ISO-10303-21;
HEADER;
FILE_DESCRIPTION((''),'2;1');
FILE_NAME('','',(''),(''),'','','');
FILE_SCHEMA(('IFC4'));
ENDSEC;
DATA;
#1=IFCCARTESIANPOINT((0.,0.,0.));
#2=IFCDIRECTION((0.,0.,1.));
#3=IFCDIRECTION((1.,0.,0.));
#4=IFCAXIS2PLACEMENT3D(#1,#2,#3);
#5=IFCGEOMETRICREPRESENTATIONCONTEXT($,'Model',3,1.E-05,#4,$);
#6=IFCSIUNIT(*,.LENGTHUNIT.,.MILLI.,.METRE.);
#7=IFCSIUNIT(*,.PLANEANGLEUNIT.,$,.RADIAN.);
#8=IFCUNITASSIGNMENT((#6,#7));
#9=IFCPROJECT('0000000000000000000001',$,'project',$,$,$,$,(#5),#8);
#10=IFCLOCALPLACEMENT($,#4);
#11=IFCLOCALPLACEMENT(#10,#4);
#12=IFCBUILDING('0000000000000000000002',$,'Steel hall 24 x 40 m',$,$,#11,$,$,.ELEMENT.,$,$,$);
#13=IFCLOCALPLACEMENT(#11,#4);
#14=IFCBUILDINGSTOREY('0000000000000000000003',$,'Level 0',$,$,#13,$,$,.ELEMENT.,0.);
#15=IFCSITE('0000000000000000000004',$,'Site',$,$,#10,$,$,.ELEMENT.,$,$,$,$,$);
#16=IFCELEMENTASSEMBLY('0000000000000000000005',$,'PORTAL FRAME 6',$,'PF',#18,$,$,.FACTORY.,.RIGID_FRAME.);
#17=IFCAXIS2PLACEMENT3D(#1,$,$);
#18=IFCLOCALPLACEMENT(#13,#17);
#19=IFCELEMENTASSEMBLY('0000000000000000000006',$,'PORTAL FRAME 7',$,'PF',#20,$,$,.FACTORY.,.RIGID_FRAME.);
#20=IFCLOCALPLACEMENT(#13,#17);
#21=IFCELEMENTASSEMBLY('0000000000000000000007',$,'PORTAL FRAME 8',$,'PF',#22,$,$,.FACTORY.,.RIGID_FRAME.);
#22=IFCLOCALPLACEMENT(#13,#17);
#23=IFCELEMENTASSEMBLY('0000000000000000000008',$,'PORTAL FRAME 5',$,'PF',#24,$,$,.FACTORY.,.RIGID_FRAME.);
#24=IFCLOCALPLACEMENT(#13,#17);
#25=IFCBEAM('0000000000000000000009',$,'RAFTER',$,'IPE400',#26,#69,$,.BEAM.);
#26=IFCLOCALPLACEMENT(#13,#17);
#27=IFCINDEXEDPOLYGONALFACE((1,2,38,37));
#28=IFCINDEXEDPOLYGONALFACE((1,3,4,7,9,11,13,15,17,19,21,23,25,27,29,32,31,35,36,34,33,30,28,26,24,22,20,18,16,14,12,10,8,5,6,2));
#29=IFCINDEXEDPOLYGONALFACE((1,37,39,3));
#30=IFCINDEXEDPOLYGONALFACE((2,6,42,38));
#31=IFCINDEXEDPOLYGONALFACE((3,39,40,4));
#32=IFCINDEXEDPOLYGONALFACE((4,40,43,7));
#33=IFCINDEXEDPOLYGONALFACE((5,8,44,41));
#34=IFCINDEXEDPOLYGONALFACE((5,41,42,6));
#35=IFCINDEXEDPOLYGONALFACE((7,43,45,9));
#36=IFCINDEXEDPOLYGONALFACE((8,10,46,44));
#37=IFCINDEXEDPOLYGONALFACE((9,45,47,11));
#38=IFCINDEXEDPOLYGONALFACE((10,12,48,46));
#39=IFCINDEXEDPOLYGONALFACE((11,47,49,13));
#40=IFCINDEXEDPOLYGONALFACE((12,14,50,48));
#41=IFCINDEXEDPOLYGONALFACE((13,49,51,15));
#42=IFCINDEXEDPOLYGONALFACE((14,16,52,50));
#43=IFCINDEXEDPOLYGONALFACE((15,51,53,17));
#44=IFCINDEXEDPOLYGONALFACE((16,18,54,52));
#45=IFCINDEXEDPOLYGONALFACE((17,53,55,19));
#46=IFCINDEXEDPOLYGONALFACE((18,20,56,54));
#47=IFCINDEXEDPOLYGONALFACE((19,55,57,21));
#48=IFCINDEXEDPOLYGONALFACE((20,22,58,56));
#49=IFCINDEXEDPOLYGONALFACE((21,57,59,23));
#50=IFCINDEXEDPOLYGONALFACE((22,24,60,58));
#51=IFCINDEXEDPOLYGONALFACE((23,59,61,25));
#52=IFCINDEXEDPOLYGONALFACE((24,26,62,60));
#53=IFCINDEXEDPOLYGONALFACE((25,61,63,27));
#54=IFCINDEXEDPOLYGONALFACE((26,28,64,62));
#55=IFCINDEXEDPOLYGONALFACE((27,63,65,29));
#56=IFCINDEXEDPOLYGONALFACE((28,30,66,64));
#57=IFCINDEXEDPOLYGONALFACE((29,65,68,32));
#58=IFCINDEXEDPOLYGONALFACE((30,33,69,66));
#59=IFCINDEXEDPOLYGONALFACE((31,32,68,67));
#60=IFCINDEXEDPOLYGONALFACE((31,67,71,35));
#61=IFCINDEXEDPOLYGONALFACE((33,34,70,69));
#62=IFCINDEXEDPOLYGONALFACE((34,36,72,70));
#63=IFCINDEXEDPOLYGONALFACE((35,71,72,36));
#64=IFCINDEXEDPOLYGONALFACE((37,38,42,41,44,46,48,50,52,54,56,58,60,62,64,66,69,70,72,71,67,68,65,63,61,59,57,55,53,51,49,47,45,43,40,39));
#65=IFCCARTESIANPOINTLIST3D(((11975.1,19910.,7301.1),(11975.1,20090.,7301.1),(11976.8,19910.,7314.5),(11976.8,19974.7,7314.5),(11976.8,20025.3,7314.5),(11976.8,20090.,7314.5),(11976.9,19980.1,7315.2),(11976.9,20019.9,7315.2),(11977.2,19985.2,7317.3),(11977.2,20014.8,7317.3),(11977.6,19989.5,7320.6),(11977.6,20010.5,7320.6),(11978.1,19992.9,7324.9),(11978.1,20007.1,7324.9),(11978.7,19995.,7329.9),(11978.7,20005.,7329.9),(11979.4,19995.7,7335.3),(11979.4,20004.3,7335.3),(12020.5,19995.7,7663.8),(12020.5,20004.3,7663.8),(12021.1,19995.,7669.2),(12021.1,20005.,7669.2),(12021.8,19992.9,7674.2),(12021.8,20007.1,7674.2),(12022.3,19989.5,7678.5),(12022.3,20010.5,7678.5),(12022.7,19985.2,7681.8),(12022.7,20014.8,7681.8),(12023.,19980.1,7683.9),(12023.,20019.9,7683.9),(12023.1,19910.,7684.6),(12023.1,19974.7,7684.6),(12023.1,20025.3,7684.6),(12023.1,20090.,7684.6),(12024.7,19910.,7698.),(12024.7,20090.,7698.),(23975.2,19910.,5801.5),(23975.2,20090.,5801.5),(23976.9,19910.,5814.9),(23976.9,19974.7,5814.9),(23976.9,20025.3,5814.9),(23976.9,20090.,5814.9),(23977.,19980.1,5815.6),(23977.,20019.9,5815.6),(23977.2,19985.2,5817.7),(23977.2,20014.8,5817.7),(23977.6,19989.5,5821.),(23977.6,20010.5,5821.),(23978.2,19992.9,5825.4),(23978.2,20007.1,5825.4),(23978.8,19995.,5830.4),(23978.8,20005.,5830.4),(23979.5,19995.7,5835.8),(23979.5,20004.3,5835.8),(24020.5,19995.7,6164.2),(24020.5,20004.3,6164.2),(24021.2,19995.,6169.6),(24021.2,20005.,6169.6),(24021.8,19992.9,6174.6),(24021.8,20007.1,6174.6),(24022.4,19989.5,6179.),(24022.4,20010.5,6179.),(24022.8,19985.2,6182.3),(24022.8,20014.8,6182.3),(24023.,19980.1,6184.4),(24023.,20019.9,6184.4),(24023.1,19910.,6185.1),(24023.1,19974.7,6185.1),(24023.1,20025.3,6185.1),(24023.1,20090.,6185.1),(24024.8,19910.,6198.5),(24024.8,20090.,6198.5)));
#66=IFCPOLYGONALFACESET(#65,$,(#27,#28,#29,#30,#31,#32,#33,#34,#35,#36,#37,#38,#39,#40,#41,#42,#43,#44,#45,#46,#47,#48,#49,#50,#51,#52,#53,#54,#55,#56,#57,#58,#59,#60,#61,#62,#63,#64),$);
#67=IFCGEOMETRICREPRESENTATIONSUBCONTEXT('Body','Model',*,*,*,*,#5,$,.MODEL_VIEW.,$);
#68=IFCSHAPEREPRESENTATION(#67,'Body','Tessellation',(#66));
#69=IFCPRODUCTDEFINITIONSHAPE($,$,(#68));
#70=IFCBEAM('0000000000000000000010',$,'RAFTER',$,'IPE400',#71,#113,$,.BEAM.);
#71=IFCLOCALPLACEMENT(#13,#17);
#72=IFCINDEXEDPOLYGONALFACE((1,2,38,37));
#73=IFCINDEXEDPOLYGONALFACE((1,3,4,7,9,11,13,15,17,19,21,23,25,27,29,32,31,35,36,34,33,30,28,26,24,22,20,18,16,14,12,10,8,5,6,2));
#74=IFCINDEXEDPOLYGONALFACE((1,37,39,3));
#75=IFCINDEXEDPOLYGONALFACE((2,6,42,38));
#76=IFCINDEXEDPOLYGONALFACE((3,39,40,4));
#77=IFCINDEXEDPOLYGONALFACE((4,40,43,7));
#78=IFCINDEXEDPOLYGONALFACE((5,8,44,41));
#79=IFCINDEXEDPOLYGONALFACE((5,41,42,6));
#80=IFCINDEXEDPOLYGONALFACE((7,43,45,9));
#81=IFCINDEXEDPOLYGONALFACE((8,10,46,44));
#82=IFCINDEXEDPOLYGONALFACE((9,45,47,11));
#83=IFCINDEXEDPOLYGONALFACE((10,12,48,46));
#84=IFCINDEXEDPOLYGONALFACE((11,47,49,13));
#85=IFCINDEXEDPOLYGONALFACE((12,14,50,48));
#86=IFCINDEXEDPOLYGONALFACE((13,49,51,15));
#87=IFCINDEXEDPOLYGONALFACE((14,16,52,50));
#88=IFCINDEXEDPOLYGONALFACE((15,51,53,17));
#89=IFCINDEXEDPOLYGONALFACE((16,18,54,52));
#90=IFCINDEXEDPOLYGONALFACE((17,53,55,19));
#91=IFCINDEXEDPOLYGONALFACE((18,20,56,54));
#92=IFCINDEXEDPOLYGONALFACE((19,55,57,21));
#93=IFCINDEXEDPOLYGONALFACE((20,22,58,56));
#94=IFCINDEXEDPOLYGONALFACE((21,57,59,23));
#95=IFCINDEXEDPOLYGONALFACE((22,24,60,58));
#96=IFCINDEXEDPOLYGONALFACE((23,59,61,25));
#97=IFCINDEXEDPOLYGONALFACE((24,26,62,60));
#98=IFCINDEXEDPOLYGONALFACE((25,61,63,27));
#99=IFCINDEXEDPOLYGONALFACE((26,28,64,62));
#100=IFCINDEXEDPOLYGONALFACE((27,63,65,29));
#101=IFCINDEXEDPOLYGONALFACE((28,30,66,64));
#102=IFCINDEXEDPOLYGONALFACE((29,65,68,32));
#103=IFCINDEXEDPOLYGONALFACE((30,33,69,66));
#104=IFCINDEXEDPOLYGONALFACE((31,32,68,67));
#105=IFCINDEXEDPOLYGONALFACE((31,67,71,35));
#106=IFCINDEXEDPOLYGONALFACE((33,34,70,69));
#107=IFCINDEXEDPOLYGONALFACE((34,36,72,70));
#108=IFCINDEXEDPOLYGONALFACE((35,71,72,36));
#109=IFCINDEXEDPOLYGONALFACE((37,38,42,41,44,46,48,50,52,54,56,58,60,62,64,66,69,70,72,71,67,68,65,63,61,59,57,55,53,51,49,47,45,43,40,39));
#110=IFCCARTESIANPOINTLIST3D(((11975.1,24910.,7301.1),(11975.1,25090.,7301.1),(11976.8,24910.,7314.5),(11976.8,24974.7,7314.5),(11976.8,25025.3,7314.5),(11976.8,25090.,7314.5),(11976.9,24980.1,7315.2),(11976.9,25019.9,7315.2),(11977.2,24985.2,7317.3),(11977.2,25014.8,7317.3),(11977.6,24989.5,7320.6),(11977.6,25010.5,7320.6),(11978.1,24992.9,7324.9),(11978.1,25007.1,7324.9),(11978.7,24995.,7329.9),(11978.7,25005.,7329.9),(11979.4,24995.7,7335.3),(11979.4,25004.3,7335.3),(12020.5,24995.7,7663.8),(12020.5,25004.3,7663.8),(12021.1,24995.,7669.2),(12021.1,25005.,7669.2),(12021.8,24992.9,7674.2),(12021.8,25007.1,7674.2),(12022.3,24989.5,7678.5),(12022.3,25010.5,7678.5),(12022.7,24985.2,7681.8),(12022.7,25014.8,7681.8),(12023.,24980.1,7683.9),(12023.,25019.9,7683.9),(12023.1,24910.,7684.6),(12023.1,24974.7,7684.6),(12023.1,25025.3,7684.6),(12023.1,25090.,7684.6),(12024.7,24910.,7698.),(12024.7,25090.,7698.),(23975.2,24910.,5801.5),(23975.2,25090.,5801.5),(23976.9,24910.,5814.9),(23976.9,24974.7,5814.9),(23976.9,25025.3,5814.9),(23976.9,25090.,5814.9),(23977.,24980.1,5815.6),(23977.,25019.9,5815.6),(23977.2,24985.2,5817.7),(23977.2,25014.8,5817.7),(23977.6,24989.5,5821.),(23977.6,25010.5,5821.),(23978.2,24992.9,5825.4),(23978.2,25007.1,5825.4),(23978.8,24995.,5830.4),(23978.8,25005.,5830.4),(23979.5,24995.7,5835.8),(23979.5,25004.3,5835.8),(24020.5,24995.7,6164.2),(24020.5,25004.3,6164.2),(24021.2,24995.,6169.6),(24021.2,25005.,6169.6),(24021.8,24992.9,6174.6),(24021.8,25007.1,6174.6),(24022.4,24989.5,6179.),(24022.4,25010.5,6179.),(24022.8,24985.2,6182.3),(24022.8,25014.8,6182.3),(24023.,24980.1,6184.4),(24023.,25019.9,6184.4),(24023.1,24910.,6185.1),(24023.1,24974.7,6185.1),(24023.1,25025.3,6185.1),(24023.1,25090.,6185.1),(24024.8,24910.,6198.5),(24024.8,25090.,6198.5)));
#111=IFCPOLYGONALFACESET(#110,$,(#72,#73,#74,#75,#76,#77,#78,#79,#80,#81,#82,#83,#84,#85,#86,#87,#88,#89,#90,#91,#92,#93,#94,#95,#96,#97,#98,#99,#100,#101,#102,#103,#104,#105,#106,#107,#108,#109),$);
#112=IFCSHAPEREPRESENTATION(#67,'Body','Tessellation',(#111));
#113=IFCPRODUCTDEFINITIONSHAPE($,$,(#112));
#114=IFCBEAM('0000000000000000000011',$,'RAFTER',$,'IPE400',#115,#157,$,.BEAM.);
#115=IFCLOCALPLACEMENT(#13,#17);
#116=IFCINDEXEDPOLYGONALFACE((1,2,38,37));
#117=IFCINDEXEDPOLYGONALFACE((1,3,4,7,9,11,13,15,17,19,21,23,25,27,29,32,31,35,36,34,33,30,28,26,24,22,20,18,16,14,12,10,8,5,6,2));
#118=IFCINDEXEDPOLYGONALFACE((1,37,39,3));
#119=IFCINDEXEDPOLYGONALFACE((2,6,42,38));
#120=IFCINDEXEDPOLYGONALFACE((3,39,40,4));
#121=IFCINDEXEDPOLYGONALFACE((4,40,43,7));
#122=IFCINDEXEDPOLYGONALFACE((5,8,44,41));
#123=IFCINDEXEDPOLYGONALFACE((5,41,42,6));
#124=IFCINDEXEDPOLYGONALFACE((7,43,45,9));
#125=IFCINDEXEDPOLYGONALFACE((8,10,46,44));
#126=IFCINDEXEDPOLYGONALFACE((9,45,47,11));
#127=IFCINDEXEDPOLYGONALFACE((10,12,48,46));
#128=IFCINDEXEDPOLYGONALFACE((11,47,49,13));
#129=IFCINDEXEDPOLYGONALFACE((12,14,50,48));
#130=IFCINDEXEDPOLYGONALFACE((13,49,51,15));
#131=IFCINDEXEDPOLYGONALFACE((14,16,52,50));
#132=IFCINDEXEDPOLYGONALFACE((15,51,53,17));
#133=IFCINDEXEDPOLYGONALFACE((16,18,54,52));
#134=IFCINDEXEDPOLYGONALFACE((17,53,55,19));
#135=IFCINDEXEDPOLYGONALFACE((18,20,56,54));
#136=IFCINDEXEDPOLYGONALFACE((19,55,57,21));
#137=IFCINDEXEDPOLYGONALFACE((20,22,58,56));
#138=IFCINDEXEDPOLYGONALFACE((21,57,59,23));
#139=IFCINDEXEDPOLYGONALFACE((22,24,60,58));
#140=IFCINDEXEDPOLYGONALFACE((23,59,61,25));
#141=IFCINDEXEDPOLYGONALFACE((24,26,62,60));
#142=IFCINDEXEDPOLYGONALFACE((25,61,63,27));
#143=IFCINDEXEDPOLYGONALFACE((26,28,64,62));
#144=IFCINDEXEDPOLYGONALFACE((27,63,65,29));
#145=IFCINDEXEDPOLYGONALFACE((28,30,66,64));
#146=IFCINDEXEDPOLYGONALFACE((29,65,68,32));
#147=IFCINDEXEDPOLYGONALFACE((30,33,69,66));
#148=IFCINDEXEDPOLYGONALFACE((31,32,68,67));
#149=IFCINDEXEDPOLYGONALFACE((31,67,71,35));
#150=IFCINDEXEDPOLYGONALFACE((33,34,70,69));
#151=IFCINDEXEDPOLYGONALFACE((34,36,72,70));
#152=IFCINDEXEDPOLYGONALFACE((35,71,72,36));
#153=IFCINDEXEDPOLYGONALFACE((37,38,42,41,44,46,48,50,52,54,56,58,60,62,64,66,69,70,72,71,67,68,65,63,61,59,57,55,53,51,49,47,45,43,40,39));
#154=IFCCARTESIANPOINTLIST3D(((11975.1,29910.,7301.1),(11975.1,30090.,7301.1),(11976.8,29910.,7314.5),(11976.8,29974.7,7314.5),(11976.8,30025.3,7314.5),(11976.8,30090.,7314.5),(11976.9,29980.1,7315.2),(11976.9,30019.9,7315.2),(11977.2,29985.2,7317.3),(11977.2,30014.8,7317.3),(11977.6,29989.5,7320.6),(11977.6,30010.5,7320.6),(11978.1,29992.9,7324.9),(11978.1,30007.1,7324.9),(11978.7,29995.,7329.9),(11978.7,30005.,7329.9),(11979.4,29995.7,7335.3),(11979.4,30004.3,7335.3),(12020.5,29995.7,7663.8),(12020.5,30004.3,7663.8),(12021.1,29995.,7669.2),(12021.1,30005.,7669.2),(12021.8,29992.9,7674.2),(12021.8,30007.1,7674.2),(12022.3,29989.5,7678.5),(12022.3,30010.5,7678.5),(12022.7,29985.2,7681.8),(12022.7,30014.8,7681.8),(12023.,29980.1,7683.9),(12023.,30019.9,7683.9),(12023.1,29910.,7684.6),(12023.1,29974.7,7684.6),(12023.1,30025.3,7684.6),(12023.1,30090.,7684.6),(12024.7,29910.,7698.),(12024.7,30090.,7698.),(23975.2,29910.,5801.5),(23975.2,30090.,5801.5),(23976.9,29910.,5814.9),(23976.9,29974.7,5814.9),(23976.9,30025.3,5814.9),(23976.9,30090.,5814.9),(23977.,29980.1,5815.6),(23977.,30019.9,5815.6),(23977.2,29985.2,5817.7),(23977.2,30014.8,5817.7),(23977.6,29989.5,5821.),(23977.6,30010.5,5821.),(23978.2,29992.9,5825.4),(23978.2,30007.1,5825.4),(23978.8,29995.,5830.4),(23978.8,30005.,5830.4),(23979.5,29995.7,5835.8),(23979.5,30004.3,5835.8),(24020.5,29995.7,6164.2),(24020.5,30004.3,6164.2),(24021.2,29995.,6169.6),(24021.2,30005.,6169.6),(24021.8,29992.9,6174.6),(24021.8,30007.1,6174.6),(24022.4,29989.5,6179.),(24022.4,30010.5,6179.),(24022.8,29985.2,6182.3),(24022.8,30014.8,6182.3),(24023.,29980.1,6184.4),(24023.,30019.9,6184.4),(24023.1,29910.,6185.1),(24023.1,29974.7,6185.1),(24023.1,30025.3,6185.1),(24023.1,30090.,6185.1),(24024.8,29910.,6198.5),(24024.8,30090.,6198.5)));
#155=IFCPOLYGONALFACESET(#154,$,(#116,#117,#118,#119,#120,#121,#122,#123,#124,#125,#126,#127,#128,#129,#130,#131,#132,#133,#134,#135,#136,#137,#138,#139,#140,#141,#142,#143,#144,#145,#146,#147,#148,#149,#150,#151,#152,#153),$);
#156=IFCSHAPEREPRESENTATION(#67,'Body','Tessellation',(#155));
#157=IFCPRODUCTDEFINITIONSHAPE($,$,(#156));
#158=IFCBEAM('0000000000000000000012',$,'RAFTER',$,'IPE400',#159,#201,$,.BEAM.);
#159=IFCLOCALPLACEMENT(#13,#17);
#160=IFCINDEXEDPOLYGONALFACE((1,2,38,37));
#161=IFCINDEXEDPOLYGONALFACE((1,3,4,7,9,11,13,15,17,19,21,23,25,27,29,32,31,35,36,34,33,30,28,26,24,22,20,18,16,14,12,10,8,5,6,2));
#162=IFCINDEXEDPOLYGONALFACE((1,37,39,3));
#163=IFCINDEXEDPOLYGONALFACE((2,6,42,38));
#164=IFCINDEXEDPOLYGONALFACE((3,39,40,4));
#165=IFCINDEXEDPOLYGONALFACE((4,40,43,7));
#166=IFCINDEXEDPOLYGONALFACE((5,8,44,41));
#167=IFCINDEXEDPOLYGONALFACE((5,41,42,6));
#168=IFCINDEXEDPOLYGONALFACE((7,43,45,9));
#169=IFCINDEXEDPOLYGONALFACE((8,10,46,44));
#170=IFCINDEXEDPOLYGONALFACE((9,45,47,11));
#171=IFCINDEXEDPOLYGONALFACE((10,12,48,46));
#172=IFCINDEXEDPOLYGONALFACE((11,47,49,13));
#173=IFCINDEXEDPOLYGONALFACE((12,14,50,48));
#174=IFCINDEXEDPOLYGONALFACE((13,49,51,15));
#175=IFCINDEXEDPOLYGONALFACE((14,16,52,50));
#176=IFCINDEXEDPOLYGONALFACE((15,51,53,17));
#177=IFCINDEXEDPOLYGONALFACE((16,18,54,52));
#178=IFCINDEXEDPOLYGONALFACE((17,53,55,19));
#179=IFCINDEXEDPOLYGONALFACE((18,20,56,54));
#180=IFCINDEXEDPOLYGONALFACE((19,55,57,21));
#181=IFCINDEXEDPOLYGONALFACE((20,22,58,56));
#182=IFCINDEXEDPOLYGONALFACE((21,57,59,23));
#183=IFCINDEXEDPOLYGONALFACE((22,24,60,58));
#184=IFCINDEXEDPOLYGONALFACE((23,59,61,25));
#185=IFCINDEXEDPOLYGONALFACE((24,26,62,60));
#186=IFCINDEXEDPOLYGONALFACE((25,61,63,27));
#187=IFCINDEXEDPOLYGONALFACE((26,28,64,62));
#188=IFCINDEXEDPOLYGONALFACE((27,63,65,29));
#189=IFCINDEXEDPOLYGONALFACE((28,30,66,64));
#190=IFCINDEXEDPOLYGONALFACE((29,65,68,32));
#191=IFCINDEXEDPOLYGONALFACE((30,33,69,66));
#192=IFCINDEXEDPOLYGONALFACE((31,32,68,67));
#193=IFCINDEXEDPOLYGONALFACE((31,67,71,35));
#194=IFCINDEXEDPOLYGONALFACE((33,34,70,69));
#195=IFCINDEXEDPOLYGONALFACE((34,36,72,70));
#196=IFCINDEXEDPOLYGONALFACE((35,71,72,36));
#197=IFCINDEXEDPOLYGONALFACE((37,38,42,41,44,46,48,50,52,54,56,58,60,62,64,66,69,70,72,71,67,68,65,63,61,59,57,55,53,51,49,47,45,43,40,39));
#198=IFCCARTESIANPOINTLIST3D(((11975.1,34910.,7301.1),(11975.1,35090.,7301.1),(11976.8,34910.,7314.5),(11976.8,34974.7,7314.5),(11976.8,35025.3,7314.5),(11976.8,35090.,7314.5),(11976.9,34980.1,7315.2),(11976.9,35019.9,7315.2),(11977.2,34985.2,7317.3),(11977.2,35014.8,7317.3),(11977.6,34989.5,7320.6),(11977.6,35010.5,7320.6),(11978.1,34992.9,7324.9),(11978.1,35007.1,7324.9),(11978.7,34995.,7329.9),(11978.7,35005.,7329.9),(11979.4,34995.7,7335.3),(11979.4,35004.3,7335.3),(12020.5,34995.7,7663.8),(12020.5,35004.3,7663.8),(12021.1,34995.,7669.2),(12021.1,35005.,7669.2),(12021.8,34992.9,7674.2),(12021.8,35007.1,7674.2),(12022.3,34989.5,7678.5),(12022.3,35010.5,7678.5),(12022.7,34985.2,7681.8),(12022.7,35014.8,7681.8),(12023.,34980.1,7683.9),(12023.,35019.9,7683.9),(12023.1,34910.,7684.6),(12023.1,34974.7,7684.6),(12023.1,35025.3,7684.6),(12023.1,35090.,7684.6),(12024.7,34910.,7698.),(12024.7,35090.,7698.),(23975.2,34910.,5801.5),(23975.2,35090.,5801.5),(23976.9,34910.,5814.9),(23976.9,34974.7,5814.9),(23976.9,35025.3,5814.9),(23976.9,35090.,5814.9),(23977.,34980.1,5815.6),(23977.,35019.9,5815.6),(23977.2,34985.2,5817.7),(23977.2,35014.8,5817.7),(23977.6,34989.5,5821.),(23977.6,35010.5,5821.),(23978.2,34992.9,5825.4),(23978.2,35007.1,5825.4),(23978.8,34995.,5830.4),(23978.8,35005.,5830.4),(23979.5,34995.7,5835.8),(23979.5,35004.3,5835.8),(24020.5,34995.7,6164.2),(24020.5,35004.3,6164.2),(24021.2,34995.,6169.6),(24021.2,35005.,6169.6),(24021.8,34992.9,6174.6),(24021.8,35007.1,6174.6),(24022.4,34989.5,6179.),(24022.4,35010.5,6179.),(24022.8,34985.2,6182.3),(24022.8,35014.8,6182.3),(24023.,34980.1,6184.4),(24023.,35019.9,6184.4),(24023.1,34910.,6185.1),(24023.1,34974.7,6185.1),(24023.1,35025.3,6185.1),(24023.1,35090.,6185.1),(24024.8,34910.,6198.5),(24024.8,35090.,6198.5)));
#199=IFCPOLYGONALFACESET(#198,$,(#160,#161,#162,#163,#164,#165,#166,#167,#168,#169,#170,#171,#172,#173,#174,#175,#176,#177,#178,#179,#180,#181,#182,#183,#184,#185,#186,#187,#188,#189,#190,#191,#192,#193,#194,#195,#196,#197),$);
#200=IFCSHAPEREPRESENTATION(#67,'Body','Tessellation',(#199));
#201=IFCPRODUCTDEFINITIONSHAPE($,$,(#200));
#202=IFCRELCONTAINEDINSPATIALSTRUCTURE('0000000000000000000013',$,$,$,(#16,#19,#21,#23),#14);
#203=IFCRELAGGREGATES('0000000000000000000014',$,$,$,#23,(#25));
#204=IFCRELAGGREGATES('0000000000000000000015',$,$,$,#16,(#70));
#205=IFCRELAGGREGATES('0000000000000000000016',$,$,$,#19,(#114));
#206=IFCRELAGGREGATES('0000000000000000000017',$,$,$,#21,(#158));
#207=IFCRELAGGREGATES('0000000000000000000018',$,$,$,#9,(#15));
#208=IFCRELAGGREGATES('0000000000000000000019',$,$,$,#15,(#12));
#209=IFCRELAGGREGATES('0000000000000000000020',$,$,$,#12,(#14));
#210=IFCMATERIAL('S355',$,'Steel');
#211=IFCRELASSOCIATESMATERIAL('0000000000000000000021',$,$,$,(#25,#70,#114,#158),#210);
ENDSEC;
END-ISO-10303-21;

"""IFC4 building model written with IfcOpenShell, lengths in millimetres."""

from ifc_helpers import new_model, si_unit, frame, origin_with_axes, place, context, subcontext, project, spatial, i_section, extrude, material, element, aggregate, save


model = new_model("IFC4")

# Units and contexts
model_context = context("Model", 3, precision=1e-05, world=origin_with_axes())
body_context = subcontext(model_context, "Body", "Model", "MODEL_VIEW")
ifc_project = project(units=[si_unit("LENGTHUNIT", "METRE", prefix="MILLI"), si_unit("PLANEANGLEUNIT", "RADIAN")], contexts=[model_context])

# Site, building, storey
site_placement = place(None, origin_with_axes())
site = spatial("IfcSite", under=ifc_project, at=site_placement, Name="Site", CompositionType="ELEMENT")
building_placement = place(site_placement, origin_with_axes())
building = spatial("IfcBuilding", under=site, at=building_placement, Name="Steel hall 24 x 40 m", CompositionType="ELEMENT")
storey_placement = place(building_placement, origin_with_axes())
storey = spatial("IfcBuildingStorey", under=building, at=storey_placement, Name="Level 0", CompositionType="ELEMENT", Elevation=0.0)

# Element assemblies
assembly_1_placement = place(storey_placement, frame((0.0, 25000.0, 0.0), z_axis=(0.0, 0.0, 1.0), x_axis=(1.0, 0.0, 0.0)))
assembly_1 = element("IfcElementAssembly", 1, at=assembly_1_placement, inside=storey, Name="PORTAL FRAME 6", ObjectType="PF", AssemblyPlace="FACTORY", PredefinedType="RIGID_FRAME")
ifc_material = material(Name="S355", Category="Steel")
assembly_2_placement = place(storey_placement, frame((0.0, 30000.0, 0.0), z_axis=(0.0, 0.0, 1.0), x_axis=(1.0, 0.0, 0.0)))
assembly_2 = element("IfcElementAssembly", 2, at=assembly_2_placement, inside=storey, Name="PORTAL FRAME 7", ObjectType="PF", AssemblyPlace="FACTORY", PredefinedType="RIGID_FRAME")
assembly_3_placement = place(storey_placement, frame((0.0, 35000.0, 0.0), z_axis=(0.0, 0.0, 1.0), x_axis=(1.0, 0.0, 0.0)))
assembly_3 = element("IfcElementAssembly", 3, at=assembly_3_placement, inside=storey, Name="PORTAL FRAME 8", ObjectType="PF", AssemblyPlace="FACTORY", PredefinedType="RIGID_FRAME")

# Element assembly, beam
assembly_4_placement = place(storey_placement, frame((0.0, 20000.0, 0.0), z_axis=(0.0, 0.0, 1.0), x_axis=(1.0, 0.0, 0.0)))
assembly_4 = element("IfcElementAssembly", 4, at=assembly_4_placement, inside=storey, Name="PORTAL FRAME 5", ObjectType="PF", AssemblyPlace="FACTORY", PredefinedType="RIGID_FRAME")
beam_1_placement = place(storey_placement, frame((24000.0, 20000.0, 6000.0), z_axis=(-0.9923, 0.0, 0.124), x_axis=(0.0, 1.0, 0.0)))
beam_1 = element("IfcBeam", 5, at=beam_1_placement, material=ifc_material, Name="RAFTER", ObjectType="IPE400", PredefinedType="BEAM", context=body_context, shape_type="SweptSolid", body=[
    extrude(i_section(OverallWidth=180.0, OverallDepth=400.0, WebThickness=8.6, FlangeThickness=13.5, FilletRadius=21.0), origin_with_axes(), (0.0, 0.0, 1.0), 12093.4),
])

# Beams
beam_2_placement = place(storey_placement, frame((24000.0, 25000.0, 6000.0), z_axis=(-0.9923, 0.0, 0.124), x_axis=(0.0, 1.0, 0.0)))
beam_2 = element("IfcBeam", 6, at=beam_2_placement, material=ifc_material, Name="RAFTER", ObjectType="IPE400", PredefinedType="BEAM", context=body_context, shape_type="SweptSolid", body=[
    extrude(i_section(OverallWidth=180.0, OverallDepth=400.0, WebThickness=8.6, FlangeThickness=13.5, FilletRadius=21.0), origin_with_axes(), (0.0, 0.0, 1.0), 12093.4),
])
beam_3_placement = place(storey_placement, frame((24000.0, 30000.0, 6000.0), z_axis=(-0.9923, 0.0, 0.124), x_axis=(0.0, 1.0, 0.0)))
beam_3 = element("IfcBeam", 7, at=beam_3_placement, material=ifc_material, Name="RAFTER", ObjectType="IPE400", PredefinedType="BEAM", context=body_context, shape_type="SweptSolid", body=[
    extrude(i_section(OverallWidth=180.0, OverallDepth=400.0, WebThickness=8.6, FlangeThickness=13.5, FilletRadius=21.0), origin_with_axes(), (0.0, 0.0, 1.0), 12093.4),
])
beam_4_placement = place(storey_placement, frame((24000.0, 35000.0, 6000.0), z_axis=(-0.9923, 0.0, 0.124), x_axis=(0.0, 1.0, 0.0)))
beam_4 = element("IfcBeam", 8, at=beam_4_placement, material=ifc_material, Name="RAFTER", ObjectType="IPE400", PredefinedType="BEAM", context=body_context, shape_type="SweptSolid", body=[
    extrude(i_section(OverallWidth=180.0, OverallDepth=400.0, WebThickness=8.6, FlangeThickness=13.5, FilletRadius=21.0), origin_with_axes(), (0.0, 0.0, 1.0), 12093.4),
])

aggregate(assembly_4, [beam_1])
aggregate(assembly_1, [beam_2])
aggregate(assembly_2, [beam_3])
aggregate(assembly_3, [beam_4])

save(model, "model.ifc")
